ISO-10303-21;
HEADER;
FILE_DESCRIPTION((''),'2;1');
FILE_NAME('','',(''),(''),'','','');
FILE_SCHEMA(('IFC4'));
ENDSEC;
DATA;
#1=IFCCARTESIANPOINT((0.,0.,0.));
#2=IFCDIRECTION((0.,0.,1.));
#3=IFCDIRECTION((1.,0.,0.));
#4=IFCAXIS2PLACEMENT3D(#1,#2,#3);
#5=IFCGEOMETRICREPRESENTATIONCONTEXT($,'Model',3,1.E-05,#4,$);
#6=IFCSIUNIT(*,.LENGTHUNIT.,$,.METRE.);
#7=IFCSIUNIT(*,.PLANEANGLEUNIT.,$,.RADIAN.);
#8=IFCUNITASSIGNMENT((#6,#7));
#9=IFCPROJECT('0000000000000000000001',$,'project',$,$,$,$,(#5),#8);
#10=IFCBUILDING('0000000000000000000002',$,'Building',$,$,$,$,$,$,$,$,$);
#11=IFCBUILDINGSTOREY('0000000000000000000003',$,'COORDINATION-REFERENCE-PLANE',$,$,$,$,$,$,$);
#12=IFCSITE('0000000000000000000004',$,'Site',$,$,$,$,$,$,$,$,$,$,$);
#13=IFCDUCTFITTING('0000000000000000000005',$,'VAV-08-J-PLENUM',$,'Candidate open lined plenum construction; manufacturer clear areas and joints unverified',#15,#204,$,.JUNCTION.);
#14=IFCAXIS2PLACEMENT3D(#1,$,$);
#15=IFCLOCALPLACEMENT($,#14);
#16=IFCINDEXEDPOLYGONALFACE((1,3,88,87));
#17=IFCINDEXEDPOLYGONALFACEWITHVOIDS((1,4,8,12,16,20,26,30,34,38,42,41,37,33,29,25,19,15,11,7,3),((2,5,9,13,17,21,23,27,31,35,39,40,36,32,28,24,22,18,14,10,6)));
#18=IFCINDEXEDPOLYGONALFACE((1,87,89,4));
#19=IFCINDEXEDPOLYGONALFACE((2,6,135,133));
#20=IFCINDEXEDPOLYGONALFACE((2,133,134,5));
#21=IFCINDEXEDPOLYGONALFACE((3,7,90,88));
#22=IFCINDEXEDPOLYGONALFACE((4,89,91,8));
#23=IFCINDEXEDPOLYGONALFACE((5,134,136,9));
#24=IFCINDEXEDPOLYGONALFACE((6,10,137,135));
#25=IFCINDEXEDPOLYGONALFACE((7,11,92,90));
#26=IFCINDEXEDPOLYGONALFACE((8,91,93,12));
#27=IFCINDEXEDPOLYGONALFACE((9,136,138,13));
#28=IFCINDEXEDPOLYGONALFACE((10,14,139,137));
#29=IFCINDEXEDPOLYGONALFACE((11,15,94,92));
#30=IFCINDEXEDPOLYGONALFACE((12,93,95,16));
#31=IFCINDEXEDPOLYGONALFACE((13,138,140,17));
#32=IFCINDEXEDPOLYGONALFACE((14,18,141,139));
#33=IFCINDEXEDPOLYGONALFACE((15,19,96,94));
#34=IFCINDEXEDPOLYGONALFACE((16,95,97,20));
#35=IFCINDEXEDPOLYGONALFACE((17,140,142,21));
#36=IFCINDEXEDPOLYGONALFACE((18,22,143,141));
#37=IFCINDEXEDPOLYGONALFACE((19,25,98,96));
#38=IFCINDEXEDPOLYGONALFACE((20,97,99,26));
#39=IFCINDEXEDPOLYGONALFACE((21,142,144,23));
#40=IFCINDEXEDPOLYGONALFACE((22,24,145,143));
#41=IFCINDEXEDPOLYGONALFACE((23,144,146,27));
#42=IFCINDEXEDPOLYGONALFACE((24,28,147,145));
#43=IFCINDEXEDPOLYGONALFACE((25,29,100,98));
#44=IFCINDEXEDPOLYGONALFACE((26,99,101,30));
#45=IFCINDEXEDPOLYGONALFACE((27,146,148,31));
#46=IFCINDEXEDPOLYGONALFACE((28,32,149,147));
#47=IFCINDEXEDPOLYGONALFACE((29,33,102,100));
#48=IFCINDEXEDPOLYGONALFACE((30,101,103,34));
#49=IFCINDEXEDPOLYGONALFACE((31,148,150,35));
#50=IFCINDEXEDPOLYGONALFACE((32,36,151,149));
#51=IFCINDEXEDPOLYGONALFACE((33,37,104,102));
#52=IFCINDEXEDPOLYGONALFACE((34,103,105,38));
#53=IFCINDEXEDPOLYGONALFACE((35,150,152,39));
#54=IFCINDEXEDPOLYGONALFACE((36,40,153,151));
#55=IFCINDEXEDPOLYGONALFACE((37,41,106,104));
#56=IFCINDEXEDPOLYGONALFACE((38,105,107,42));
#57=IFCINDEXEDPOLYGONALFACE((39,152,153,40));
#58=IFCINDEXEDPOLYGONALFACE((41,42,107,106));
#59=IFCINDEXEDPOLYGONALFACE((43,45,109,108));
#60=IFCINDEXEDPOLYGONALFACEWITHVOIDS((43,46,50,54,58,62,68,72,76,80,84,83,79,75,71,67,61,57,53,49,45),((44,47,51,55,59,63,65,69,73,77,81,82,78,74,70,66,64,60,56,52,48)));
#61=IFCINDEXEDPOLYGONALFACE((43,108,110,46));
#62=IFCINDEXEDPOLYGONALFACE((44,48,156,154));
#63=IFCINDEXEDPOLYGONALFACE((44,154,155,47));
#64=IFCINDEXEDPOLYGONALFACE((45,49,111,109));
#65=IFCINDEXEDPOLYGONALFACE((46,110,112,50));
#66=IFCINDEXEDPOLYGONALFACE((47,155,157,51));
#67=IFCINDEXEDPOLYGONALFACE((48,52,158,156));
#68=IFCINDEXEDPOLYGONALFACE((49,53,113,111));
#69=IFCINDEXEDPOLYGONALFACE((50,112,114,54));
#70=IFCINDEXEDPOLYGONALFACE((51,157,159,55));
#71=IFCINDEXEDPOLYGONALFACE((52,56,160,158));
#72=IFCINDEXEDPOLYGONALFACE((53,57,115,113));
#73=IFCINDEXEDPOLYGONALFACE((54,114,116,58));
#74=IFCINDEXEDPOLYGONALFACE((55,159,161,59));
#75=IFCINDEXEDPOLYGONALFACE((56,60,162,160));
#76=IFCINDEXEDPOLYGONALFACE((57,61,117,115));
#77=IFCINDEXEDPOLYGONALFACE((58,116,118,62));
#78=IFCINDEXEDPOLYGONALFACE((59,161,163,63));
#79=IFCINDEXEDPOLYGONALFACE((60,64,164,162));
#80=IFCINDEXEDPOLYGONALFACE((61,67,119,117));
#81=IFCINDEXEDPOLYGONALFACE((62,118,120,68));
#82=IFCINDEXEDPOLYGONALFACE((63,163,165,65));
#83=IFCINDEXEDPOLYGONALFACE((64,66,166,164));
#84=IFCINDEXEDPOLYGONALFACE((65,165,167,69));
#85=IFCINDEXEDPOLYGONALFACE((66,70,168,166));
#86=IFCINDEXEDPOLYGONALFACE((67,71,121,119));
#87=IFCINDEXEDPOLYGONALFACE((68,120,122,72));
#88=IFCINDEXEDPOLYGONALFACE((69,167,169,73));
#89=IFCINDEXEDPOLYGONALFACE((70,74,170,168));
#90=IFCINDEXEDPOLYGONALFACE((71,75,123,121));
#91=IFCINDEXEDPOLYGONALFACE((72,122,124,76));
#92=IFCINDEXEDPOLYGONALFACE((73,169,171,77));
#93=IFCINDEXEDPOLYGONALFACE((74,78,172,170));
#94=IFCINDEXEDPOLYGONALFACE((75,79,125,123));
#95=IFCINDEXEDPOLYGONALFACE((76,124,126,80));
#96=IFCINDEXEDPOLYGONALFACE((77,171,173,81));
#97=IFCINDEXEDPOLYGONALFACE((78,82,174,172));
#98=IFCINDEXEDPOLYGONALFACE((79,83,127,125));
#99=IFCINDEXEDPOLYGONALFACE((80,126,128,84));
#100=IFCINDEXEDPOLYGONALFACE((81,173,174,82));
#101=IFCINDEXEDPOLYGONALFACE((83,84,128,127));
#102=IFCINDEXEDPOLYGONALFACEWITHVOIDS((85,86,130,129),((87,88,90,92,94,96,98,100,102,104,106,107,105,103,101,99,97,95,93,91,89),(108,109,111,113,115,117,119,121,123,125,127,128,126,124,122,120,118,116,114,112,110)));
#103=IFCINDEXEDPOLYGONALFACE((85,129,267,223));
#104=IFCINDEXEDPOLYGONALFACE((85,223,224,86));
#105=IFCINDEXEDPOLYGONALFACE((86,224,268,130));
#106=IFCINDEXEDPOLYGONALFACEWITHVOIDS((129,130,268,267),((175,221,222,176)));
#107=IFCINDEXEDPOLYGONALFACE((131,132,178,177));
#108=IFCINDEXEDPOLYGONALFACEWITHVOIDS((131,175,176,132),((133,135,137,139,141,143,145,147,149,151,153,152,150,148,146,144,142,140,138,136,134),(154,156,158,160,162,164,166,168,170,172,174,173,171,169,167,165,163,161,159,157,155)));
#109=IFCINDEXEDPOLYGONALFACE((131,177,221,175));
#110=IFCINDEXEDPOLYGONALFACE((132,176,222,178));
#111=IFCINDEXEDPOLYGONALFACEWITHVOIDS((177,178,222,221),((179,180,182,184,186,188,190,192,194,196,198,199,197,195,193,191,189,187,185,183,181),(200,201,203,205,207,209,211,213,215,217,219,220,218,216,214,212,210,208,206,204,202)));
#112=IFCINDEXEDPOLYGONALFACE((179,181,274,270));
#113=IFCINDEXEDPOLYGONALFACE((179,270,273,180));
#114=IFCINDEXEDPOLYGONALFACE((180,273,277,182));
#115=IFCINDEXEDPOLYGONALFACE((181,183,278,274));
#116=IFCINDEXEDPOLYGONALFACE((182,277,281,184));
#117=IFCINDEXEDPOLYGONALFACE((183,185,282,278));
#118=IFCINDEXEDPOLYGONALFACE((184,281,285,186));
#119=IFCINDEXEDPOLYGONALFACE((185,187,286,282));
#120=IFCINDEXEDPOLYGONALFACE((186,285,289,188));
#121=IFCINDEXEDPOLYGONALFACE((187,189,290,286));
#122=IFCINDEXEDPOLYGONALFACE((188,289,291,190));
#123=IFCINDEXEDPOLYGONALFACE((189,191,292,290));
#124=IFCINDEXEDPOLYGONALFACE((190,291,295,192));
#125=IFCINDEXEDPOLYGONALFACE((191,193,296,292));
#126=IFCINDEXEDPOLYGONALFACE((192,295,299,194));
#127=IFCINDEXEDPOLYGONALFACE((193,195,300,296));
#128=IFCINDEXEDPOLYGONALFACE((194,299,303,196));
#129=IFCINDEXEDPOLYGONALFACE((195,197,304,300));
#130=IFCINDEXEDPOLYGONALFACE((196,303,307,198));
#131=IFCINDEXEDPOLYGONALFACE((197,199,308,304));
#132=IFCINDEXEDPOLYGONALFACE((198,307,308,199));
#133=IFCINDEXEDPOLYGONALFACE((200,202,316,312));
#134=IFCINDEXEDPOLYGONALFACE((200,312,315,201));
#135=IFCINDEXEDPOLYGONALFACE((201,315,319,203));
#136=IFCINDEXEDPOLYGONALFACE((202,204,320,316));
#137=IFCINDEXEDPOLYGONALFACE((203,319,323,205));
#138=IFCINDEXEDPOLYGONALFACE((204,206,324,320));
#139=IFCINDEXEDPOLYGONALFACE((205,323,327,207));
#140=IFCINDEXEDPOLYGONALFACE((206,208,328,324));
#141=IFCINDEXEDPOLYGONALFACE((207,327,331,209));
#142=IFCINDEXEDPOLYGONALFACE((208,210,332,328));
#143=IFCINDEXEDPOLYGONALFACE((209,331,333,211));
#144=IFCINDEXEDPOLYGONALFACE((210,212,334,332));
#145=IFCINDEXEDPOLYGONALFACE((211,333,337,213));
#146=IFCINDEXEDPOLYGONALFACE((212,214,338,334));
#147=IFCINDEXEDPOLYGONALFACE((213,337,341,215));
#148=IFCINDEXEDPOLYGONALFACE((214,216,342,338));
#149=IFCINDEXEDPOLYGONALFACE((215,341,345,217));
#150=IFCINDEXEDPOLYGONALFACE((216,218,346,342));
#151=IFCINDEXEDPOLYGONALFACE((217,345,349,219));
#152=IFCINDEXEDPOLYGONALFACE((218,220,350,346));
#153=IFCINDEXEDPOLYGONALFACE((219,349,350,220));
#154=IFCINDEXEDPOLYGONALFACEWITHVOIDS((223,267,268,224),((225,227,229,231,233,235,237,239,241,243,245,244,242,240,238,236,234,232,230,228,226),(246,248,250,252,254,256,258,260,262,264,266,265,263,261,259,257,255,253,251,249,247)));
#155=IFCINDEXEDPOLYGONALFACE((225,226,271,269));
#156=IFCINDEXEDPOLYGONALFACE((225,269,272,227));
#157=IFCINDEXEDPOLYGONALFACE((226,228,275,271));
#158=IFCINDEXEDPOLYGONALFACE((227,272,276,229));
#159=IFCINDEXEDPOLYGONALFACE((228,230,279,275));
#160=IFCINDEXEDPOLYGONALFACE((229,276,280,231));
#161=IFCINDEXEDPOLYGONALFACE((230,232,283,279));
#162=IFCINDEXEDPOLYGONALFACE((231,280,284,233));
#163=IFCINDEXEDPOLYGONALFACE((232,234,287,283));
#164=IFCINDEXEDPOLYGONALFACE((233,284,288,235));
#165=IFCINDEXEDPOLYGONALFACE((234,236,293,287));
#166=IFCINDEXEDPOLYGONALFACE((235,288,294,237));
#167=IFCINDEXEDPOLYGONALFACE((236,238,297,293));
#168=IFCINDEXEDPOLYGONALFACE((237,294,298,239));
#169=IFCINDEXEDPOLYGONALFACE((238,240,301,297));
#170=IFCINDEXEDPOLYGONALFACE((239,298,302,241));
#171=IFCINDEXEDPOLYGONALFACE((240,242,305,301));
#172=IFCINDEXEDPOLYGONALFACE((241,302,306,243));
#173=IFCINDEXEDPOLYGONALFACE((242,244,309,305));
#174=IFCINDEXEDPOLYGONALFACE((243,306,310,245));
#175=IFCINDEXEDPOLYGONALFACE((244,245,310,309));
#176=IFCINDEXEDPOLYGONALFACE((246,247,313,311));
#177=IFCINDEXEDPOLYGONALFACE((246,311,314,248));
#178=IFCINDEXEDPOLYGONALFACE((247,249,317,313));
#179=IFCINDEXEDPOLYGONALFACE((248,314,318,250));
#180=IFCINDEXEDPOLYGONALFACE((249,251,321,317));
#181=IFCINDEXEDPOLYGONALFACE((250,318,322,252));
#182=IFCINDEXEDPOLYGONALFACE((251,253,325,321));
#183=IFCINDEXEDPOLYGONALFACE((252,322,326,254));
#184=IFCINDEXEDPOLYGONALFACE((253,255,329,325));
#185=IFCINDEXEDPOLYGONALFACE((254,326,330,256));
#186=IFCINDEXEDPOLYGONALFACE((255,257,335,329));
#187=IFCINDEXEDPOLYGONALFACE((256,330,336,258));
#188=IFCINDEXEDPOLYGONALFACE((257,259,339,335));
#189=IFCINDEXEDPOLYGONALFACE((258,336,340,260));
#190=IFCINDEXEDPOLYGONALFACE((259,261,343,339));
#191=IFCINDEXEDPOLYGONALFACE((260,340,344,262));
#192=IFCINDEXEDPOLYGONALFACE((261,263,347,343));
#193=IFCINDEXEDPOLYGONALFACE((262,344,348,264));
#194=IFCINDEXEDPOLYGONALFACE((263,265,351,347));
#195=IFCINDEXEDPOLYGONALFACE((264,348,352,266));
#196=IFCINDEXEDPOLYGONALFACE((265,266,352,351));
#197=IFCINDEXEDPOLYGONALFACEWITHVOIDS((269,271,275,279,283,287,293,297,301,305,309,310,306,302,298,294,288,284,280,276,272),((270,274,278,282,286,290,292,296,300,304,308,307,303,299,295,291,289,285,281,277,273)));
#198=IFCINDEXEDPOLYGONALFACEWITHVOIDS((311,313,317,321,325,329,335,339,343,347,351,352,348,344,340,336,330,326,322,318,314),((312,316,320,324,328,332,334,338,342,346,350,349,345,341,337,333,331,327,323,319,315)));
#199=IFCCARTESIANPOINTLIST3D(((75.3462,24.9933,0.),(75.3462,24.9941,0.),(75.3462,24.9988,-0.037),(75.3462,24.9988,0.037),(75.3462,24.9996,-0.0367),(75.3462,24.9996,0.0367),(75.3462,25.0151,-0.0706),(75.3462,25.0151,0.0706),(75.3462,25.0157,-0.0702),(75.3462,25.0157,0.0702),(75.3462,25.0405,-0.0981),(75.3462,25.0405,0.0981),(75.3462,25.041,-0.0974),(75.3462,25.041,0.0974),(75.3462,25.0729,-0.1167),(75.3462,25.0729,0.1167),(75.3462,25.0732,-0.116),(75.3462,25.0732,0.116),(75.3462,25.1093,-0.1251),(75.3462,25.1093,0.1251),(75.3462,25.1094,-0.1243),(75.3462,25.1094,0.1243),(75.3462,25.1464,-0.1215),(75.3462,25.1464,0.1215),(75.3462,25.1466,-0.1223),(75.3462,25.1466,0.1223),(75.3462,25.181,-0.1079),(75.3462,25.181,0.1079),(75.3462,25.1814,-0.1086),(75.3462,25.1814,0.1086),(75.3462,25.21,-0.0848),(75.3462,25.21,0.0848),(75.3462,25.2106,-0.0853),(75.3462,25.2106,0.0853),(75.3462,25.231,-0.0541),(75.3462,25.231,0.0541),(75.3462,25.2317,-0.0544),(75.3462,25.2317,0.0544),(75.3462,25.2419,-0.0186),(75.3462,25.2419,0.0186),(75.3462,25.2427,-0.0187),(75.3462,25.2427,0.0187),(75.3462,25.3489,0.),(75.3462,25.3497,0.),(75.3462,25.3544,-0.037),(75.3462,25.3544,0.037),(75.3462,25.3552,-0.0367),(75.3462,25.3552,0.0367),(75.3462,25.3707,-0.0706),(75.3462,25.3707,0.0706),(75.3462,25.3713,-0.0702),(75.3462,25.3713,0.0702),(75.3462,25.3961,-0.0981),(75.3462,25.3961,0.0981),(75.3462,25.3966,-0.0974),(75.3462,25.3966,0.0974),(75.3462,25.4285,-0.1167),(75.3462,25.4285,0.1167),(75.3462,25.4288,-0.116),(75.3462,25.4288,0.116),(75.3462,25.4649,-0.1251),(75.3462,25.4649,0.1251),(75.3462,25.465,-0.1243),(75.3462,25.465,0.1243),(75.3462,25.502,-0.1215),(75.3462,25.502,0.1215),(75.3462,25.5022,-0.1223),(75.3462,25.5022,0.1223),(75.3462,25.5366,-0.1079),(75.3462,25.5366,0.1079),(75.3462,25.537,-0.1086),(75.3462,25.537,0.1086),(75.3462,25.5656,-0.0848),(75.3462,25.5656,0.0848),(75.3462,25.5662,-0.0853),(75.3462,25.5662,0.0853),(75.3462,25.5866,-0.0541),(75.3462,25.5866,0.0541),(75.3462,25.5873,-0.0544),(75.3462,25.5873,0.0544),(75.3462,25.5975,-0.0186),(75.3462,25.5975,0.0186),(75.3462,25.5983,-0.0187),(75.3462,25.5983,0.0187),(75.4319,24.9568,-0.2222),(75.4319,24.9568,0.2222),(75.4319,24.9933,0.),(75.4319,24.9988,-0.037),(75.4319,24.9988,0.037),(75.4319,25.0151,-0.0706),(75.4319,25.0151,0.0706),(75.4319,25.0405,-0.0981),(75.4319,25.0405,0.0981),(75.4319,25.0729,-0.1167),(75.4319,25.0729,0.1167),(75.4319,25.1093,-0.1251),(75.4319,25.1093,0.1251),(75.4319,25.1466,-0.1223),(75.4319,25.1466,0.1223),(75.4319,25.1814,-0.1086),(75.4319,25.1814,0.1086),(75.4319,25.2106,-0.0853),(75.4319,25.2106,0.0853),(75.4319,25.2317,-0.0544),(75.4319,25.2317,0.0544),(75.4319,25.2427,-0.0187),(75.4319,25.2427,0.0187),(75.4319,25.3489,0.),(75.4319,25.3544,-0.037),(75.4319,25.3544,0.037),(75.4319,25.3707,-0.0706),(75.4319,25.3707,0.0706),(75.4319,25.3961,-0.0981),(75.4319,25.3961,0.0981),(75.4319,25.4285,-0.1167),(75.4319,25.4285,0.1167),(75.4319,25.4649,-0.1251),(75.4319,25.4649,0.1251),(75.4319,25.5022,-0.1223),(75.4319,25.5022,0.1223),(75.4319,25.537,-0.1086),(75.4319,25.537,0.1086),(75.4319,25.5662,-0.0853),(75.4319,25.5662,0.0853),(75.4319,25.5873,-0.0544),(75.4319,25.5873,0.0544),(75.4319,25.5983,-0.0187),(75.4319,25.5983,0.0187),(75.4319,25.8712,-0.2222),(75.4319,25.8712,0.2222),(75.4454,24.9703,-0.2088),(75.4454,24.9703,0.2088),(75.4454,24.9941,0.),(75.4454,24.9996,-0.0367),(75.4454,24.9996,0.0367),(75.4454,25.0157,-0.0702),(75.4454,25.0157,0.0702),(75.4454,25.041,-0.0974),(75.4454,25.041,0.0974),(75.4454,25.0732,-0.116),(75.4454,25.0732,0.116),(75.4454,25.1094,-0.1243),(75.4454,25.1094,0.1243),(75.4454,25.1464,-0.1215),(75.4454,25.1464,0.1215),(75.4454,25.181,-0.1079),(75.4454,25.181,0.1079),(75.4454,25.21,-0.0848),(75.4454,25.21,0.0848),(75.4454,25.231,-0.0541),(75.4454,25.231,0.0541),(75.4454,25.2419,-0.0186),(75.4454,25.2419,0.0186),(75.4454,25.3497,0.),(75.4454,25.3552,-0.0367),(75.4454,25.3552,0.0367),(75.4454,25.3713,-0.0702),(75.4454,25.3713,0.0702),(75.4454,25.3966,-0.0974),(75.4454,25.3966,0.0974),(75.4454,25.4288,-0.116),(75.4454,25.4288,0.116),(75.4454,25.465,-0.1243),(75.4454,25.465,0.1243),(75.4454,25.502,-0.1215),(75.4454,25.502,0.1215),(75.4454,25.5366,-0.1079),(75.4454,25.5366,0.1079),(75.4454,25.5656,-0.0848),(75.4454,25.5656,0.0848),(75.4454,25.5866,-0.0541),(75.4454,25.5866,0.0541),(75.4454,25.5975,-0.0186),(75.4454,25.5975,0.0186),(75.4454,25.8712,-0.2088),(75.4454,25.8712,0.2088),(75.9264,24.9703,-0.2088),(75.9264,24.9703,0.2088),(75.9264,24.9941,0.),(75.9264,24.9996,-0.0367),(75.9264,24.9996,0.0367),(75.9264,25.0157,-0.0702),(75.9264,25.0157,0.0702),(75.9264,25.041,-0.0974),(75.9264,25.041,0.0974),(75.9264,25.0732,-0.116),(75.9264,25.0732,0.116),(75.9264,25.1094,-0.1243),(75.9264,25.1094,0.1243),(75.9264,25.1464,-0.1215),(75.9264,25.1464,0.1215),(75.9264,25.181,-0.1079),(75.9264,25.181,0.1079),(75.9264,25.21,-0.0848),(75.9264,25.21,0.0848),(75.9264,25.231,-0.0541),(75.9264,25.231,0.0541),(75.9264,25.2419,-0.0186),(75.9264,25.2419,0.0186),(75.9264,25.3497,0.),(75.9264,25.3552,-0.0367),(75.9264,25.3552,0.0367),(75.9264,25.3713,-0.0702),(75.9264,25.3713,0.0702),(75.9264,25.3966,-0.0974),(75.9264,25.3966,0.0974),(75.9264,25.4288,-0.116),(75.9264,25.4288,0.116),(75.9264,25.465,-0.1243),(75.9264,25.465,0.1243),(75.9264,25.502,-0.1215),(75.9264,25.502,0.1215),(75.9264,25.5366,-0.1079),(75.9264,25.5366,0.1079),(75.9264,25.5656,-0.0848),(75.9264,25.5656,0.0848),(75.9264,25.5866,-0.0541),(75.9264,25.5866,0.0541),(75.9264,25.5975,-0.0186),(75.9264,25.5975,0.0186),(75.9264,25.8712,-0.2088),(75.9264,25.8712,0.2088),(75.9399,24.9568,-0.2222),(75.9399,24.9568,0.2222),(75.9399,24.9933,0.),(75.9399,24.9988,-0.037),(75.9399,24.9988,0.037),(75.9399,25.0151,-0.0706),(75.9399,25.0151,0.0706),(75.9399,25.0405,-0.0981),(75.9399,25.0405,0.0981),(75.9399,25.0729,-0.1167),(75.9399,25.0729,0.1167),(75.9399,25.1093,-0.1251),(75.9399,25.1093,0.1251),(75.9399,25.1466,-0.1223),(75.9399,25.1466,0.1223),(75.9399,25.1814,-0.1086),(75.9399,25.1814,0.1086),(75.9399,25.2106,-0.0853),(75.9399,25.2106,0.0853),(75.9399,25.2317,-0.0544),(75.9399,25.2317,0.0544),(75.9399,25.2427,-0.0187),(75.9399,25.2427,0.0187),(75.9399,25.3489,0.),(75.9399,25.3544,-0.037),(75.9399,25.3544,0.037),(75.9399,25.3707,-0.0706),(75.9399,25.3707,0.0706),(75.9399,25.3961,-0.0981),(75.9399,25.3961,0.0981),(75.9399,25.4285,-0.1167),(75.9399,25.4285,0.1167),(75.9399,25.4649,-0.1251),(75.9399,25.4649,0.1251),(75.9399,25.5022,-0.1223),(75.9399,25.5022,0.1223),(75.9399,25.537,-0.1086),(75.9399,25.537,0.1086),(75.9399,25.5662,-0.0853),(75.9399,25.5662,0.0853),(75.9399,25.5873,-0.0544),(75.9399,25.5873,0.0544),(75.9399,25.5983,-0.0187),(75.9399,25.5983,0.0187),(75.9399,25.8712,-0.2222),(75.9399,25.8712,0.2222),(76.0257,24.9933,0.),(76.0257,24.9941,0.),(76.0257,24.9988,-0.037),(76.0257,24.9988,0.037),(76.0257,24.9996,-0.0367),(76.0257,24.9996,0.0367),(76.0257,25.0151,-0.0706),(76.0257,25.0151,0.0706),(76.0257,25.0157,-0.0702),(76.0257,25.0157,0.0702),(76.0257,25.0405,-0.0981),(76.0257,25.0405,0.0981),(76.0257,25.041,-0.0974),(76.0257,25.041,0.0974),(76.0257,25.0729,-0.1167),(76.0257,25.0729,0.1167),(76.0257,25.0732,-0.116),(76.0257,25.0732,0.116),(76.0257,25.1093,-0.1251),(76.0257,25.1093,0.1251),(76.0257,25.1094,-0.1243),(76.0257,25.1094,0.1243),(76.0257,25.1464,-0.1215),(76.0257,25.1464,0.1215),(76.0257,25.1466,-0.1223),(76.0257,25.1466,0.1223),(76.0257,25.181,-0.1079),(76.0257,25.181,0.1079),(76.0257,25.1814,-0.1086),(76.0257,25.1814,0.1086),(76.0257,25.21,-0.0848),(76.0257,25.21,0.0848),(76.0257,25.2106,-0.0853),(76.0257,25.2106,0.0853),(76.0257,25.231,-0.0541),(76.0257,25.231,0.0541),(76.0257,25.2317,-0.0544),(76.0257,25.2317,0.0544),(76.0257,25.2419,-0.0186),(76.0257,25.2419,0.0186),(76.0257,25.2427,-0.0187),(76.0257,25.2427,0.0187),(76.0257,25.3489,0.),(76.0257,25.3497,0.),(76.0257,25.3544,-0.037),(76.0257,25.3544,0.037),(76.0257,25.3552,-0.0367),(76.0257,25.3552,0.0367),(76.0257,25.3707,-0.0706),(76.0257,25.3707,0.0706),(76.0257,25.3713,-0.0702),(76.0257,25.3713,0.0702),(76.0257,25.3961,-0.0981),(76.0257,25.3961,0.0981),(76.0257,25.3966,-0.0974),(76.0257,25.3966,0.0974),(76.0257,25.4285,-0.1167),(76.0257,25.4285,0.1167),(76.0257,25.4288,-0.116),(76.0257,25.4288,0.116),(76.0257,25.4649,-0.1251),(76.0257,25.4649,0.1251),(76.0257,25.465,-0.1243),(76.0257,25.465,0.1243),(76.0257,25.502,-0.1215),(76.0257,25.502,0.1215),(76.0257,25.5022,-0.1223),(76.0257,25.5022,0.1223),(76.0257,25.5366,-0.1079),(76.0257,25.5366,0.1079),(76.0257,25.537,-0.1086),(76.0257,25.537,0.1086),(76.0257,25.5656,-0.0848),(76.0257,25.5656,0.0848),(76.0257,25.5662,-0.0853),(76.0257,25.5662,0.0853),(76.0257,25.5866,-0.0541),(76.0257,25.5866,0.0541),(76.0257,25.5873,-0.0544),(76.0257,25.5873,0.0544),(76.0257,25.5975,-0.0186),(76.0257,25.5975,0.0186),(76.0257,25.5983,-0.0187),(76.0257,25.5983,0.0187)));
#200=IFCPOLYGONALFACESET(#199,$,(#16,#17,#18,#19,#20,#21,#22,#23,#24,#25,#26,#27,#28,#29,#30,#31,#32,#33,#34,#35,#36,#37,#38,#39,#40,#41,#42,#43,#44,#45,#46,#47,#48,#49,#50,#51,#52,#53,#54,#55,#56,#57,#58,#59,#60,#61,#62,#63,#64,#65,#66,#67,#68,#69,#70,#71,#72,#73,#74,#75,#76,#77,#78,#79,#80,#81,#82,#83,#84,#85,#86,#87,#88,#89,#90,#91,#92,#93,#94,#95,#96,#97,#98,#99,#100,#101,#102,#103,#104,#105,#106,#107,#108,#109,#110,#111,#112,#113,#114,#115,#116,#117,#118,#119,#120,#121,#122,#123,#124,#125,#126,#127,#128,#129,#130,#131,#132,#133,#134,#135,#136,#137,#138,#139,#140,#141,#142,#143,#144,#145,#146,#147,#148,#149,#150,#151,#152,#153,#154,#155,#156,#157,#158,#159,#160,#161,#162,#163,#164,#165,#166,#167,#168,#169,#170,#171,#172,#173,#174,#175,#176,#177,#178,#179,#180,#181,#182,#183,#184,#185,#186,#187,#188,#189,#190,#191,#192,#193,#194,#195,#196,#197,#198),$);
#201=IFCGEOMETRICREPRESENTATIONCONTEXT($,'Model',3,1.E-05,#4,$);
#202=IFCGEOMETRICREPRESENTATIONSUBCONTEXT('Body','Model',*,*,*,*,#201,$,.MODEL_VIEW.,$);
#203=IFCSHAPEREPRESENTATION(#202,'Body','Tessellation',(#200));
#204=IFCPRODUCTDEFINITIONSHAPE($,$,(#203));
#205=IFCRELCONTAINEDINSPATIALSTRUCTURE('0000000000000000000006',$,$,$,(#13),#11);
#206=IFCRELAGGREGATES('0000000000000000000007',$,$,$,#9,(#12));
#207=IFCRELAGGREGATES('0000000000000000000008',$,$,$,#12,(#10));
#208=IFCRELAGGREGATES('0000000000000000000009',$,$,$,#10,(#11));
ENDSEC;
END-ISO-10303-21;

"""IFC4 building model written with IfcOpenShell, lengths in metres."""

from ifc_helpers import new_model, si_unit, frame, origin_with_axes, place, context, subcontext, project, spatial, rectangle, circle, extrude, boolean, element, save


model = new_model("IFC4")

# Units and contexts
model_context_1 = context("Model", 3, precision=1e-05, world=origin_with_axes())
model_context_2 = context("Model", 3, precision=1e-05, world=origin_with_axes())
body_context_1 = subcontext(model_context_2, "Body", "Model", "MODEL_VIEW")
ifc_project = project(units=[si_unit("LENGTHUNIT", "METRE"), si_unit("PLANEANGLEUNIT", "RADIAN")], contexts=[model_context_1])

# Site, building, storey
site = spatial("IfcSite", under=ifc_project, Name="Site")
building = spatial("IfcBuilding", under=site, Name="Building")
storey = spatial("IfcBuildingStorey", under=building, Name="COORDINATION-REFERENCE-PLANE")

# Duct fitting
duct_fitting_1_placement = place(None, frame((75.4319, 24.9568, -0.2223), z_axis=(0.0, 0.0, 1.0), x_axis=(1.0, 0.0, 0.0)))
solid_1 = boolean("UNION", boolean("UNION", boolean("UNION", boolean("UNION", extrude(rectangle(XDim=0.481, YDim=0.4175), frame((0.254, 0.9244, 0.2223), z_axis=(0.0, -1.0, 0.0), x_axis=(1.0, 0.0, 0.0)), (0.0, 0.0, 1.0), 0.9109), extrude(circle(Radius=0.1246), frame((0.0235, 0.5175, 0.2223), z_axis=(-1.0, 0.0, 0.0), x_axis=(0.0, -1.0, 0.0)), (0.0, 0.0, 1.0), 0.1192)), extrude(circle(Radius=0.1246), frame((0.4845, 0.5175, 0.2223), z_axis=(1.0, 0.0, 0.0), x_axis=(0.0, -1.0, 0.0)), (0.0, 0.0, 1.0), 0.1192)), extrude(circle(Radius=0.1246), frame((0.0235, 0.1619, 0.2223), z_axis=(-1.0, 0.0, 0.0), x_axis=(0.0, -1.0, 0.0)), (0.0, 0.0, 1.0), 0.1192)), extrude(circle(Radius=0.1246), frame((0.4845, 0.1619, 0.2223), z_axis=(1.0, 0.0, 0.0), x_axis=(0.0, -1.0, 0.0)), (0.0, 0.0, 1.0), 0.1192))
element("IfcDuctFitting", 1, at=duct_fitting_1_placement, inside=storey, Name="VAV-08-J-PLENUM", ObjectType="Candidate open lined plenum construction; manufacturer clear areas and joints unverified", PredefinedType="JUNCTION", context=body_context_1, shape_type="CSG", body=[
    boolean("DIFFERENCE", boolean("UNION", boolean("UNION", boolean("UNION", boolean("UNION", extrude(rectangle(XDim=0.508, YDim=0.4445), frame((0.254, 0.9144, 0.2223), z_axis=(0.0, -1.0, 0.0), x_axis=(1.0, 0.0, 0.0)), (0.0, 0.0, 1.0), 0.9144), extrude(circle(Radius=0.1254), frame((0.0235, 0.5175, 0.2223), z_axis=(-1.0, 0.0, 0.0), x_axis=(0.0, -1.0, 0.0)), (0.0, 0.0, 1.0), 0.1092)), extrude(circle(Radius=0.1254), frame((0.4845, 0.5175, 0.2223), z_axis=(1.0, 0.0, 0.0), x_axis=(0.0, -1.0, 0.0)), (0.0, 0.0, 1.0), 0.1092)), extrude(circle(Radius=0.1254), frame((0.0235, 0.1619, 0.2223), z_axis=(-1.0, 0.0, 0.0), x_axis=(0.0, -1.0, 0.0)), (0.0, 0.0, 1.0), 0.1092)), extrude(circle(Radius=0.1254), frame((0.4845, 0.1619, 0.2223), z_axis=(1.0, 0.0, 0.0), x_axis=(0.0, -1.0, 0.0)), (0.0, 0.0, 1.0), 0.1092)), solid_1),
])

save(model, "model.ifc")
